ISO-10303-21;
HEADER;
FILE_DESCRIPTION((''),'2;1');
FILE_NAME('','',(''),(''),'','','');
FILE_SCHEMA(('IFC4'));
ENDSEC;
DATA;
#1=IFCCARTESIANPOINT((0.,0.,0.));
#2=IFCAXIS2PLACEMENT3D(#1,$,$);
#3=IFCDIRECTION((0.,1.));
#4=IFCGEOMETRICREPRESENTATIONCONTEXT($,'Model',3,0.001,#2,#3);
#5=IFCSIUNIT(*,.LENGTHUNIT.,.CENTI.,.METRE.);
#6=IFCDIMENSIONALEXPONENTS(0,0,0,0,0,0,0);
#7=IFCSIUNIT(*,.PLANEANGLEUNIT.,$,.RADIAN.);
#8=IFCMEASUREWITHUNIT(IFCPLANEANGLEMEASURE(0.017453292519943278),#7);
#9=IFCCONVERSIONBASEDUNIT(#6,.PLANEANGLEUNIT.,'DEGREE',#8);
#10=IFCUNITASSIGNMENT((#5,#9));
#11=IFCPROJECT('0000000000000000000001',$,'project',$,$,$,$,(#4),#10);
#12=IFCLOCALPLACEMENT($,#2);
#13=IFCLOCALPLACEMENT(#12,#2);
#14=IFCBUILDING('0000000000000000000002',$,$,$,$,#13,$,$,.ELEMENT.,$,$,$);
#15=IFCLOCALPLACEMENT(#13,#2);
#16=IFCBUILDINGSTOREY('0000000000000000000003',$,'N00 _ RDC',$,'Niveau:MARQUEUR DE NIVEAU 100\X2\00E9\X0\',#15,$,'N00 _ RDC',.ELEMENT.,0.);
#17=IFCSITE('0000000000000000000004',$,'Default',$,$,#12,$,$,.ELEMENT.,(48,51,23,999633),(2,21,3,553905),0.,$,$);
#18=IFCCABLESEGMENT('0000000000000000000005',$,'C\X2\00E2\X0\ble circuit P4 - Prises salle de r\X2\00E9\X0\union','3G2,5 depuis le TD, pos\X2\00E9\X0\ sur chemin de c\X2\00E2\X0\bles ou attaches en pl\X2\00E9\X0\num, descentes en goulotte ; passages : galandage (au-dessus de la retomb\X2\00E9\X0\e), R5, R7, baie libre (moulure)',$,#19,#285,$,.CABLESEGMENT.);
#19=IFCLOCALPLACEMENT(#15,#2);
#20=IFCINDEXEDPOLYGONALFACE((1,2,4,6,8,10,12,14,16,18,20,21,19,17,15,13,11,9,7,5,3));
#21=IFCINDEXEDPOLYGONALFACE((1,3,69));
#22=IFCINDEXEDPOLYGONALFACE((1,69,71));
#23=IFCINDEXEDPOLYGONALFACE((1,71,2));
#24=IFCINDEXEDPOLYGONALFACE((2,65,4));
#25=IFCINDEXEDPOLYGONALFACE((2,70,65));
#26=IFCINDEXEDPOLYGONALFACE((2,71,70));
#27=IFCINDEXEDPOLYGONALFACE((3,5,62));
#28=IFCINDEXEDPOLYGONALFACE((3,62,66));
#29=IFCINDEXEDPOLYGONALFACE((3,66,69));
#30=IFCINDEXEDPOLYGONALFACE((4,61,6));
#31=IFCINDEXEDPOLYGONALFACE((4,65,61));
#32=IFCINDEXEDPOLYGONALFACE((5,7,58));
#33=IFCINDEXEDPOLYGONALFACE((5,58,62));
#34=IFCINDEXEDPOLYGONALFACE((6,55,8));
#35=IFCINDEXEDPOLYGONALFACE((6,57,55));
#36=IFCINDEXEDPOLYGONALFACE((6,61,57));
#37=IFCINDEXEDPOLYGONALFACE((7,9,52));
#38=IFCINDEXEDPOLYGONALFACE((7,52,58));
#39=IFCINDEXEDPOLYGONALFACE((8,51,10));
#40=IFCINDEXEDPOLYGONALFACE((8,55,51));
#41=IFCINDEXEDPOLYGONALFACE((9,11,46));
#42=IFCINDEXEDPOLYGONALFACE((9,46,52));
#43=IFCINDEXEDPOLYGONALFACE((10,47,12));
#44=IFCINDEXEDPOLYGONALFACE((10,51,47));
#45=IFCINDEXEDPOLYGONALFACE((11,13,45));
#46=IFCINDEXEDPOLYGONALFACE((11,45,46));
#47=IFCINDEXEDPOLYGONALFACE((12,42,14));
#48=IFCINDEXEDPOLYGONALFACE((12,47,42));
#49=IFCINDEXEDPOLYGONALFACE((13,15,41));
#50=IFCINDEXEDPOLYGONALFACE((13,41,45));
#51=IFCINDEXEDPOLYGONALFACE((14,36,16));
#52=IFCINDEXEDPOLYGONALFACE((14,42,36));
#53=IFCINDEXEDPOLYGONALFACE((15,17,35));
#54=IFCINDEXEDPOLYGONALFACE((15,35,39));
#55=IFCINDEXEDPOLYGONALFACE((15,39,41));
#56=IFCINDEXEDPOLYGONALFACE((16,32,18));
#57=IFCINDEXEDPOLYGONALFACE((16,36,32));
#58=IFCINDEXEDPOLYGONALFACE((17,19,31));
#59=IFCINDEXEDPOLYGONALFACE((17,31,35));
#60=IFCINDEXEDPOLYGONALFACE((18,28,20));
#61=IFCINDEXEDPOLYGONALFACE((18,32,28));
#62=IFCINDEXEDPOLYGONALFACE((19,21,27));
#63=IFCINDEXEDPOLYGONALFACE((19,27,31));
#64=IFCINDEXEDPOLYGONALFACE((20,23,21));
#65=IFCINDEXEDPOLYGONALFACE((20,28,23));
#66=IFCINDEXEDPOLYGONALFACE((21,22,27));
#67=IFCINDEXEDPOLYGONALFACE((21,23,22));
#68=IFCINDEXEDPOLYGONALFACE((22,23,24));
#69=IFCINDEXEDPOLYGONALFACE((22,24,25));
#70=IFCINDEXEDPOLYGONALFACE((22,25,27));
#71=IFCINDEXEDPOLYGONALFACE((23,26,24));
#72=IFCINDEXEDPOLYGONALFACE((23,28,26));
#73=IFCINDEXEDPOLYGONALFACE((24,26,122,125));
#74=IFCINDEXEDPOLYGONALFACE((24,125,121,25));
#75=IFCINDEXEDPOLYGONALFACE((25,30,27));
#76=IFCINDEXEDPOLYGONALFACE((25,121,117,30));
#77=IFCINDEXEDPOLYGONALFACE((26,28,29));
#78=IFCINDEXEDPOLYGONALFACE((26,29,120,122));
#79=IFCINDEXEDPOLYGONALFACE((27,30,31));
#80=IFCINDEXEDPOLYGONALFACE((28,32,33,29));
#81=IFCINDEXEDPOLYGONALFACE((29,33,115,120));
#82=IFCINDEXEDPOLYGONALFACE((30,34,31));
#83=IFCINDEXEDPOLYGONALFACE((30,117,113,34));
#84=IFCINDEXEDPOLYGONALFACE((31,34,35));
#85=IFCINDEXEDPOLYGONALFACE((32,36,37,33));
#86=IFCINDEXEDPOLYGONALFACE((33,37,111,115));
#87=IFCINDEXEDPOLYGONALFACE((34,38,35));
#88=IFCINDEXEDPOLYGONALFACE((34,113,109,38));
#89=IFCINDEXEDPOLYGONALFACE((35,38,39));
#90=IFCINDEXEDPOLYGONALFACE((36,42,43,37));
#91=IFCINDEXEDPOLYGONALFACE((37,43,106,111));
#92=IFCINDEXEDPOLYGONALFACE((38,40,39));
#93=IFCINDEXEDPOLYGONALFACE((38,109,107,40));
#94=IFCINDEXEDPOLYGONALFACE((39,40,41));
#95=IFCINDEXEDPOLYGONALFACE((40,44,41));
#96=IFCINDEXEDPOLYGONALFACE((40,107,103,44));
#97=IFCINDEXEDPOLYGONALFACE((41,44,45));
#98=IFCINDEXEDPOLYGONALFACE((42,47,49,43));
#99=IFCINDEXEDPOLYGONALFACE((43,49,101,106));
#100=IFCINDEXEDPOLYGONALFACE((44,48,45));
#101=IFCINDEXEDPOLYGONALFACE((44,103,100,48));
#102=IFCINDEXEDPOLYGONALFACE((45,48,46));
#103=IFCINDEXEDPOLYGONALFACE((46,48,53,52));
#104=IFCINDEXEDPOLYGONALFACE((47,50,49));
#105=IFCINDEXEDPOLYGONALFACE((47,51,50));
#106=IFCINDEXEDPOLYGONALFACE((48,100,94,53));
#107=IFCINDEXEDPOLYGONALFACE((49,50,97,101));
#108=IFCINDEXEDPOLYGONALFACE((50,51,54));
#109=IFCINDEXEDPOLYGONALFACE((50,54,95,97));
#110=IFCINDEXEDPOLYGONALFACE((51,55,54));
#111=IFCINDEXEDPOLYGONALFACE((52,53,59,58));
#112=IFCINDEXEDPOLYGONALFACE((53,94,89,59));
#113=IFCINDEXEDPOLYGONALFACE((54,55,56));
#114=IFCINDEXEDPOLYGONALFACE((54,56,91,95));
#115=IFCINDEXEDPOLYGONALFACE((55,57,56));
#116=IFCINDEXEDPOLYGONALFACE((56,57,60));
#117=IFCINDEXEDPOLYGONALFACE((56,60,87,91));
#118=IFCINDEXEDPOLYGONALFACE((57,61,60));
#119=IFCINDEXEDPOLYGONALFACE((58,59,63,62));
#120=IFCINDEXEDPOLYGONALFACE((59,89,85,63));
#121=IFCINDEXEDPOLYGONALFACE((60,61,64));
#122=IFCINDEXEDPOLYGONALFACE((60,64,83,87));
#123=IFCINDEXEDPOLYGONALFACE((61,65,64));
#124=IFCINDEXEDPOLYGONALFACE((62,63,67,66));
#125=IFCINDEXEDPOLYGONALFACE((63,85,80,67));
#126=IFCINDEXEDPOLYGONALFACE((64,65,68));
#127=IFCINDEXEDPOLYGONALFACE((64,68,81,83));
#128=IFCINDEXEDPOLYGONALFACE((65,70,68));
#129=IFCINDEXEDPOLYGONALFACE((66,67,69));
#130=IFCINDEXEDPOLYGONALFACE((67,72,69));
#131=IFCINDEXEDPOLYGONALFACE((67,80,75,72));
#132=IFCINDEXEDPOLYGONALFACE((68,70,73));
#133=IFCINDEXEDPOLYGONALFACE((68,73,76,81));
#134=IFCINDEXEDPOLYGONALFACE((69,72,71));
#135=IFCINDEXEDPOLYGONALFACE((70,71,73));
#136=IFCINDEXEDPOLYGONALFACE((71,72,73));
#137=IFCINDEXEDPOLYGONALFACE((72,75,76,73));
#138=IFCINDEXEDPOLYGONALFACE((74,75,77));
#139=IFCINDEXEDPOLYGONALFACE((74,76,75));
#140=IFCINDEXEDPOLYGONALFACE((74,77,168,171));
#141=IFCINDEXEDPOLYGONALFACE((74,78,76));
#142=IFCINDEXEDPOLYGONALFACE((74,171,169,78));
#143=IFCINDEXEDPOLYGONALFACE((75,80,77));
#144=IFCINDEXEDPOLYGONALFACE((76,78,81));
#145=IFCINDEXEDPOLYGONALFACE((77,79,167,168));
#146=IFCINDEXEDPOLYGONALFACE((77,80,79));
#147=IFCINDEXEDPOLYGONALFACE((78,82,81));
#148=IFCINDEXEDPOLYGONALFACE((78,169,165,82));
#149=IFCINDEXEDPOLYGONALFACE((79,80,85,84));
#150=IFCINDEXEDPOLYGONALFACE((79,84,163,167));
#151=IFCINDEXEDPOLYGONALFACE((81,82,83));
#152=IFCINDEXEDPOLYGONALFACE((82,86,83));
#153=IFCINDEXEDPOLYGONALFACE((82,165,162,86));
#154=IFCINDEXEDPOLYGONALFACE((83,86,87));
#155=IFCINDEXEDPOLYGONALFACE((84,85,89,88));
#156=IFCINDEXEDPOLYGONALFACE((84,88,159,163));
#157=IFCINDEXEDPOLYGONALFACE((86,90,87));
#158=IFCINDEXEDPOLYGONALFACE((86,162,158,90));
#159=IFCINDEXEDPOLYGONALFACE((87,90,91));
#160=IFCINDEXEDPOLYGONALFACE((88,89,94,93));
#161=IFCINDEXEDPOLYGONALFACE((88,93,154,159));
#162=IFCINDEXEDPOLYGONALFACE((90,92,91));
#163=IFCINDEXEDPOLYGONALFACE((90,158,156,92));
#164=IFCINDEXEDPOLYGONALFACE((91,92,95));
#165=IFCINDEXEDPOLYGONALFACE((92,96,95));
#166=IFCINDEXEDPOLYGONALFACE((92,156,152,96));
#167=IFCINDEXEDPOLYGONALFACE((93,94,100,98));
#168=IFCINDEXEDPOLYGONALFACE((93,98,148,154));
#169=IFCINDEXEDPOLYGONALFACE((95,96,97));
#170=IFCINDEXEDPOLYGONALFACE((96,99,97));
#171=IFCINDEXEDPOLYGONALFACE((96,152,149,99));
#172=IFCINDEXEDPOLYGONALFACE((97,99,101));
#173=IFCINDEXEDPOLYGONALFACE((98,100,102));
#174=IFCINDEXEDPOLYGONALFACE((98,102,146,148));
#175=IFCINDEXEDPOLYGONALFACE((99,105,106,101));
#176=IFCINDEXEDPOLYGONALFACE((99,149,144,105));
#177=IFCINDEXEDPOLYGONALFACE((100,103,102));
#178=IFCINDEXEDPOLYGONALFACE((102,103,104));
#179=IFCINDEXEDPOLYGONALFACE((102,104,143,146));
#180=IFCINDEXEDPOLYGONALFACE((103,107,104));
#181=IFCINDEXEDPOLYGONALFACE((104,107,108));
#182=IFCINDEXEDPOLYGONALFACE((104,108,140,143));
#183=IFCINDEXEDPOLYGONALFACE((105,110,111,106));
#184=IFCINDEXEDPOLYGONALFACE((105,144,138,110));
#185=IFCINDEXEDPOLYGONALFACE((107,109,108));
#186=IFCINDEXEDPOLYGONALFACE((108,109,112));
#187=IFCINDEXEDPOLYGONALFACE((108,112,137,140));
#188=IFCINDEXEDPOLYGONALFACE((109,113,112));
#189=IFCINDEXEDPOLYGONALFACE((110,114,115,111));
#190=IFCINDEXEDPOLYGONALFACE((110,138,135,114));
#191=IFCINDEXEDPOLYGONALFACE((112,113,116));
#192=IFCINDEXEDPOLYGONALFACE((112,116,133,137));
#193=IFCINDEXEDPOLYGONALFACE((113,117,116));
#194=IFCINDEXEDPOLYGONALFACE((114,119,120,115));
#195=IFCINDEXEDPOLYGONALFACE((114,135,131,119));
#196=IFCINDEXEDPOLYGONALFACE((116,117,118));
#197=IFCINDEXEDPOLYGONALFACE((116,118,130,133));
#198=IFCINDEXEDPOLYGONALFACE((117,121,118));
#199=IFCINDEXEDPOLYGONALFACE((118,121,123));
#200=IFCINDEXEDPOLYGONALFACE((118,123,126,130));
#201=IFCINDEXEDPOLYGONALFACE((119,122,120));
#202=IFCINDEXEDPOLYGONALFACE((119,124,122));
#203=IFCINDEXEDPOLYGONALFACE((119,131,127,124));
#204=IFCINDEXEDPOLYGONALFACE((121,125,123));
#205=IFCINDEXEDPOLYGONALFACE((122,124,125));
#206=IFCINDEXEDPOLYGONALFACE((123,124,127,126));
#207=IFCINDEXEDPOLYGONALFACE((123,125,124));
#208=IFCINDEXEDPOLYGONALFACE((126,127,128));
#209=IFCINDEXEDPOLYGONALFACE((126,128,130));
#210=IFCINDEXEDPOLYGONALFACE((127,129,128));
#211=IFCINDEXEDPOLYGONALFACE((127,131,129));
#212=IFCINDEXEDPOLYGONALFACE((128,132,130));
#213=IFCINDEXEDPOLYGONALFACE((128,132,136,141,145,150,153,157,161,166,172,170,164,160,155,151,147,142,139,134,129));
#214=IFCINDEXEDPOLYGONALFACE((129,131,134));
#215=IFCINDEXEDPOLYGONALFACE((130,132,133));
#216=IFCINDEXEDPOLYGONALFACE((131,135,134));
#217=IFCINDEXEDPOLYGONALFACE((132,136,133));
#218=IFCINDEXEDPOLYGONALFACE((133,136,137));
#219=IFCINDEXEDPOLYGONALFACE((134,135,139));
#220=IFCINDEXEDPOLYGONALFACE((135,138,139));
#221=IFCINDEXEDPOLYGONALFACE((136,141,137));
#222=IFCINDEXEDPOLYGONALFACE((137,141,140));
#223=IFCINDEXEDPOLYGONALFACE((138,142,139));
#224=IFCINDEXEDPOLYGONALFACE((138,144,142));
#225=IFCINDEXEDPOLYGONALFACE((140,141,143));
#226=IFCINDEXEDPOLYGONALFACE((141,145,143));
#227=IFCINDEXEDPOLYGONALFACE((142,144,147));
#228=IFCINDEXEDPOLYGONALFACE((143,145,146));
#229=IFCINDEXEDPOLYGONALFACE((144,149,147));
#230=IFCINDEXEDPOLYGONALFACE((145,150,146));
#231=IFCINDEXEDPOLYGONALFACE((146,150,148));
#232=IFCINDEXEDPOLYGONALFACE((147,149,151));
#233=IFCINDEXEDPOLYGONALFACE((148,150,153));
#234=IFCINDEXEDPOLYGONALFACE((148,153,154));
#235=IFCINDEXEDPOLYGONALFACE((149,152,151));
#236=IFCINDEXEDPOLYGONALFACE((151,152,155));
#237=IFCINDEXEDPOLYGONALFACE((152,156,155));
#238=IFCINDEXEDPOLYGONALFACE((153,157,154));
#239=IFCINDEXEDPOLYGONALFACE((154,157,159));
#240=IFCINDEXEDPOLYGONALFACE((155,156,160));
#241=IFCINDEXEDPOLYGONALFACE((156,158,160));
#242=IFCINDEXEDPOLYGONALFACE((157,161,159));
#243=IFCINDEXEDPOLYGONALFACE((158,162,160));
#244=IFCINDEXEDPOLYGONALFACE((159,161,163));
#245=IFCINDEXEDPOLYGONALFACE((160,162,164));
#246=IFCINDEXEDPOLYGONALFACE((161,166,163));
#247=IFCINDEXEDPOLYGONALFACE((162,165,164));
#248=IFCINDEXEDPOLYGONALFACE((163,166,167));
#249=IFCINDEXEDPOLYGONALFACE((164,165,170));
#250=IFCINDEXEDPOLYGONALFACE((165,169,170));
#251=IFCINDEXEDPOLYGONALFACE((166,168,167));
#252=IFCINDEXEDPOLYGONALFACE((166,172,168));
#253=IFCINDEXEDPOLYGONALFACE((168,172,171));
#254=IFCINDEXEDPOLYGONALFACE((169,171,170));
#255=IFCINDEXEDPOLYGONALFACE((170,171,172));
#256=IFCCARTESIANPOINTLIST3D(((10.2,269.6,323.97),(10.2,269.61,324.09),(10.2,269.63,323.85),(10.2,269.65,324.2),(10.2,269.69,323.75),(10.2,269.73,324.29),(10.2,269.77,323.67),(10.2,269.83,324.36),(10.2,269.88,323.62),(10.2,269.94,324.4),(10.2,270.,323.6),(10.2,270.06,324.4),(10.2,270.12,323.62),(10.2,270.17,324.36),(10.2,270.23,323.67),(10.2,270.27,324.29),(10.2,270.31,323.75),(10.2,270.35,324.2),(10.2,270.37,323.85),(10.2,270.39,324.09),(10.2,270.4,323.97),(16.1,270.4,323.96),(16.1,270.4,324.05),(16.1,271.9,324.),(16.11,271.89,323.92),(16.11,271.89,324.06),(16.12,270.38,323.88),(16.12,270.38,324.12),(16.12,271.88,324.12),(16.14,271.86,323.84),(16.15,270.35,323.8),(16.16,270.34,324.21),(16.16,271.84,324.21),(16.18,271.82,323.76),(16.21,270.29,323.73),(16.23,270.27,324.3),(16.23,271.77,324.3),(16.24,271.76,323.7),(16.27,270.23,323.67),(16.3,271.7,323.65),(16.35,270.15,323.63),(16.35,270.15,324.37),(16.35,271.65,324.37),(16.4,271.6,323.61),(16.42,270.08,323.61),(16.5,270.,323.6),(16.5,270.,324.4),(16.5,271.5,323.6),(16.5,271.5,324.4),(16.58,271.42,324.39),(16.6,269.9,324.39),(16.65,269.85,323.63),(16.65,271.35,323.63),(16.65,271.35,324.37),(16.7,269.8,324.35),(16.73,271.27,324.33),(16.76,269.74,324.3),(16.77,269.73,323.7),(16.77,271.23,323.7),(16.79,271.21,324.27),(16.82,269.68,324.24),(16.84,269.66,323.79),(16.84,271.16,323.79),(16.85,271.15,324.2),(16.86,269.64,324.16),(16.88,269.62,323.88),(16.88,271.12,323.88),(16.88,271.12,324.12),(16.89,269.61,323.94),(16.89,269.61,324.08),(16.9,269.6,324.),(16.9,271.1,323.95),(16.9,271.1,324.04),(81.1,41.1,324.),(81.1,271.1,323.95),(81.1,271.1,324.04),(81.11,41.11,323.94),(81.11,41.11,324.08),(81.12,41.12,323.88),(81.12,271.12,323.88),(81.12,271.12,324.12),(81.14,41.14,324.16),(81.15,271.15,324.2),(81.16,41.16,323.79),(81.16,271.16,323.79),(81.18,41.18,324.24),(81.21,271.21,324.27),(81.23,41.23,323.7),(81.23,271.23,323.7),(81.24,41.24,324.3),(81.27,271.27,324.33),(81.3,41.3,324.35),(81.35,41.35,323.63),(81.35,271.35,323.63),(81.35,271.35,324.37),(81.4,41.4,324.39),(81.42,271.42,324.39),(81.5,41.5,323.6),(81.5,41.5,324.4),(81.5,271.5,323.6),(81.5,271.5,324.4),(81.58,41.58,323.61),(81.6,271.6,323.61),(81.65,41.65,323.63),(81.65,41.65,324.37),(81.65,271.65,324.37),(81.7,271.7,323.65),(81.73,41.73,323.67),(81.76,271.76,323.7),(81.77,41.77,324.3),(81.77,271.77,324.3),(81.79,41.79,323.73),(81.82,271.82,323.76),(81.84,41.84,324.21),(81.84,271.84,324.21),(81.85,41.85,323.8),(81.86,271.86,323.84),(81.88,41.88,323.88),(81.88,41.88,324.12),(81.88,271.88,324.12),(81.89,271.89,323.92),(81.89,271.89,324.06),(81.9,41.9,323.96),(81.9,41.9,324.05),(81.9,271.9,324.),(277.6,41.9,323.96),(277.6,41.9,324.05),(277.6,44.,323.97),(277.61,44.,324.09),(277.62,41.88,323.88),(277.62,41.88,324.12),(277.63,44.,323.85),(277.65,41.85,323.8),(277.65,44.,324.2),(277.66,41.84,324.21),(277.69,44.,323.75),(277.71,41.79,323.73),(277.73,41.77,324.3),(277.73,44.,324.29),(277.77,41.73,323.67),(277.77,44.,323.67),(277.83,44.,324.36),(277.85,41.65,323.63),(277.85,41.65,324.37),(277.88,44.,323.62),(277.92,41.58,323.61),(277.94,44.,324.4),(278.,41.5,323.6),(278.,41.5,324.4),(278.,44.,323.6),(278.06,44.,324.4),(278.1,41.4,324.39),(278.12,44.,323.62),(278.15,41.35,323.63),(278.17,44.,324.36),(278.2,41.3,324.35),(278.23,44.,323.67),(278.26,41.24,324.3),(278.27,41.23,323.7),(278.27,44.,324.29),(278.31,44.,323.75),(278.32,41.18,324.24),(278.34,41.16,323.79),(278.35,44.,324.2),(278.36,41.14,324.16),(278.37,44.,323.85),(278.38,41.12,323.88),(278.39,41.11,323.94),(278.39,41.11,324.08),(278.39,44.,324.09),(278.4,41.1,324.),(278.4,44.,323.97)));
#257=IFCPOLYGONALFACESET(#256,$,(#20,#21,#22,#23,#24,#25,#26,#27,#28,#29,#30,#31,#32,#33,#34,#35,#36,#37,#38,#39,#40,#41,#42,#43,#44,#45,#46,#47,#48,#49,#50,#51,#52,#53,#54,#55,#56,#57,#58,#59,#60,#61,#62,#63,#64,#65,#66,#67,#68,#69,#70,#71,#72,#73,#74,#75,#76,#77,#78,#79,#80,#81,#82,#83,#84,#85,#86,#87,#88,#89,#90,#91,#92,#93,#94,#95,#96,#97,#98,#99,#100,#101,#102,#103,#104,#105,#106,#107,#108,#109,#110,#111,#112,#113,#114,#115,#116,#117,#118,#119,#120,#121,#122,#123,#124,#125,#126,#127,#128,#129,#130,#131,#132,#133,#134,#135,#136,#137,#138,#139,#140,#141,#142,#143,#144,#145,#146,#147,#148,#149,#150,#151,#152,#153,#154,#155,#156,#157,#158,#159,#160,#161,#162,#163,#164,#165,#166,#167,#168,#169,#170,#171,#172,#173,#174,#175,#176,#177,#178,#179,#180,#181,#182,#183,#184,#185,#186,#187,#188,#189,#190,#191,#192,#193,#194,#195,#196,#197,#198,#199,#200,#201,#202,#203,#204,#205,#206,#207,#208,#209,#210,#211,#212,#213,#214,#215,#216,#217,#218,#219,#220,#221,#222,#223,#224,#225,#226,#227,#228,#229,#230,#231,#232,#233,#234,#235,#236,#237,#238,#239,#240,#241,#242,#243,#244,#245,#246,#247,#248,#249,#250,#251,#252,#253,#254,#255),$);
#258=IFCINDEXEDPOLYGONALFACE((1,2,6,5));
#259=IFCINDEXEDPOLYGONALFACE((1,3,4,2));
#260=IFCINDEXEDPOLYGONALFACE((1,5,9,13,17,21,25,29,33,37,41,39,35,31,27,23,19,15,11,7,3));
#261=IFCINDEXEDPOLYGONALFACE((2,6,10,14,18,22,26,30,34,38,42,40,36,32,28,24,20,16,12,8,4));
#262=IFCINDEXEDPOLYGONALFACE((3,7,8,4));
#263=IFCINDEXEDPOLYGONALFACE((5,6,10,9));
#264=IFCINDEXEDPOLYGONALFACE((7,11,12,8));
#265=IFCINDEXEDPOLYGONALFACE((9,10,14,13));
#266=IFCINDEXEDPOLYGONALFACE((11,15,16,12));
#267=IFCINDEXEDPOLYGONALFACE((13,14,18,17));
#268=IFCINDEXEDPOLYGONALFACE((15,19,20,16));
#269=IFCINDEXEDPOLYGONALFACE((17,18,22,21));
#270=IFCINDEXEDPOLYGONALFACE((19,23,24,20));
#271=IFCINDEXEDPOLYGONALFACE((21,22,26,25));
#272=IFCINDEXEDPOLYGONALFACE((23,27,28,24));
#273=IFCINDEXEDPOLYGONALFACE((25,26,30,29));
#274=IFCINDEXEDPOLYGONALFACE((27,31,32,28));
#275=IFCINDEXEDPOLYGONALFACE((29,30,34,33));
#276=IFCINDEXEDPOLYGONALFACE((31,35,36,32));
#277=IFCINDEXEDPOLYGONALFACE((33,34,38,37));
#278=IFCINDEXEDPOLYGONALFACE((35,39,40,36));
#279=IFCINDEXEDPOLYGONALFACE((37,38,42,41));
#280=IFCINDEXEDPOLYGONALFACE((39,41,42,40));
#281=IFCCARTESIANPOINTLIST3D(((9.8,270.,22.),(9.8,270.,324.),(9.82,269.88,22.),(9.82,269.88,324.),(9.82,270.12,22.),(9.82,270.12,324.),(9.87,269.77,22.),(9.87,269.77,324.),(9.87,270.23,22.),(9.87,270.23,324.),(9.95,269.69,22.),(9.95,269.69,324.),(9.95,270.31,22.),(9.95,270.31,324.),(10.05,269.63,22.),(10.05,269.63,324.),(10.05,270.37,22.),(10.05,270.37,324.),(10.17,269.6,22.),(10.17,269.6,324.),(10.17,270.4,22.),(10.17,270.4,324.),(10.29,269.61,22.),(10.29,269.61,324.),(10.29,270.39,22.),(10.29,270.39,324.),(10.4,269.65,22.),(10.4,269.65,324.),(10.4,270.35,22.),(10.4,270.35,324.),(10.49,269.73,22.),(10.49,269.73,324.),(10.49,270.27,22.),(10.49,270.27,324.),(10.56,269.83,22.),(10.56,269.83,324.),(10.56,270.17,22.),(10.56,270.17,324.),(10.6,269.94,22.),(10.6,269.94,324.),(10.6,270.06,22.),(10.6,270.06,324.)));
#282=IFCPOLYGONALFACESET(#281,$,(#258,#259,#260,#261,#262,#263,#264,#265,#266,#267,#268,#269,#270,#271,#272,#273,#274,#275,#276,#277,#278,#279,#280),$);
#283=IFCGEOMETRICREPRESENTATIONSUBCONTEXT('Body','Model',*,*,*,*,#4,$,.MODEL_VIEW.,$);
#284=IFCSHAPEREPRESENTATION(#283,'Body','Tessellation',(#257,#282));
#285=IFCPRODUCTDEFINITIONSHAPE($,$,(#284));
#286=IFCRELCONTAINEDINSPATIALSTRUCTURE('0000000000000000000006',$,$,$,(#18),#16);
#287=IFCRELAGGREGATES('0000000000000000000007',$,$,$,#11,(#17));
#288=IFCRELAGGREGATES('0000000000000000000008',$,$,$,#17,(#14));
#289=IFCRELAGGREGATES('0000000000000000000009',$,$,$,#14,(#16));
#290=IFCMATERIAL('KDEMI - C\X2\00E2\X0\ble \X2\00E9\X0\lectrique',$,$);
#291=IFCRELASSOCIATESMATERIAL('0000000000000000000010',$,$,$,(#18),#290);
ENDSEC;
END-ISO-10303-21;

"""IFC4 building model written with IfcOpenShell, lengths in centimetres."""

from ifc_helpers import new_model, entity, si_unit, converted_unit, direction, origin, origin_with_axes, place, context, subcontext, project, spatial, material, element, save


model = new_model("IFC4")

# Units and contexts
model_context = context("Model", 3, precision=0.001, world=origin(), true_north=direction((0.0, 1.0)))
body_context = subcontext(model_context, "Body", "Model", "MODEL_VIEW")
ifc_project = project(units=[si_unit("LENGTHUNIT", "METRE", prefix="CENTI"), converted_unit("PLANEANGLEUNIT", "DEGREE", entity("IfcPlaneAngleMeasure", 0.017453292519943278), si_unit("PLANEANGLEUNIT", "RADIAN"), dimensions=[0, 0, 0, 0, 0, 0, 0])], contexts=[model_context])

# Site, building, storey
site_placement = place(None, origin())
site = spatial("IfcSite", under=ifc_project, at=site_placement, Name="Default", CompositionType="ELEMENT", RefLatitude=(48, 51, 23, 999633), RefLongitude=(2, 21, 3, 553905), RefElevation=0.0)
building_placement = place(site_placement, origin())
building = spatial("IfcBuilding", under=site, at=building_placement, CompositionType="ELEMENT")
storey_placement = place(building_placement, origin())
storey = spatial("IfcBuildingStorey", under=building, at=storey_placement, Name="N00 _ RDC", ObjectType="Niveau:MARQUEUR DE NIVEAU 100é", LongName="N00 _ RDC", CompositionType="ELEMENT", Elevation=0.0)

# Cable segment
ifc_material_1 = material(Name="KDEMI - Câble électrique")
cable_segment_1_placement = place(storey_placement, origin_with_axes())
element("IfcCableSegment", 1, at=cable_segment_1_placement, inside=storey, material=ifc_material_1, Name="Câble circuit P4 - Prises salle de réunion", Description="3G2,5 depuis le TD, posé sur chemin de câbles ou attaches en plénum, descentes en goulotte ; passages : galandage (au-dessus de la retombée), R5, R7, baie libre (moulure)", PredefinedType="CABLESEGMENT", context=body_context, shape_type="AdvancedSweptSolid", body=[
    entity("IfcSweptDiskSolid", entity("IfcPolyline", [entity("IfcCartesianPoint", [278.0, 44.0, 324.0]), entity("IfcCartesianPoint", [278.0, 41.5, 324.0]), entity("IfcCartesianPoint", [81.5, 41.5, 324.0]), entity("IfcCartesianPoint", [81.5, 271.5, 324.0]), entity("IfcCartesianPoint", [16.5, 271.5, 324.0]), entity("IfcCartesianPoint", [16.5, 270.0, 324.0]), entity("IfcCartesianPoint", [10.2, 270.0, 324.0])]), 0.4),
    entity("IfcSweptDiskSolid", entity("IfcPolyline", [entity("IfcCartesianPoint", [10.2, 270.0, 324.0]), entity("IfcCartesianPoint", [10.2, 270.0, 22.0])]), 0.4),
])

save(model, "model.ifc")
